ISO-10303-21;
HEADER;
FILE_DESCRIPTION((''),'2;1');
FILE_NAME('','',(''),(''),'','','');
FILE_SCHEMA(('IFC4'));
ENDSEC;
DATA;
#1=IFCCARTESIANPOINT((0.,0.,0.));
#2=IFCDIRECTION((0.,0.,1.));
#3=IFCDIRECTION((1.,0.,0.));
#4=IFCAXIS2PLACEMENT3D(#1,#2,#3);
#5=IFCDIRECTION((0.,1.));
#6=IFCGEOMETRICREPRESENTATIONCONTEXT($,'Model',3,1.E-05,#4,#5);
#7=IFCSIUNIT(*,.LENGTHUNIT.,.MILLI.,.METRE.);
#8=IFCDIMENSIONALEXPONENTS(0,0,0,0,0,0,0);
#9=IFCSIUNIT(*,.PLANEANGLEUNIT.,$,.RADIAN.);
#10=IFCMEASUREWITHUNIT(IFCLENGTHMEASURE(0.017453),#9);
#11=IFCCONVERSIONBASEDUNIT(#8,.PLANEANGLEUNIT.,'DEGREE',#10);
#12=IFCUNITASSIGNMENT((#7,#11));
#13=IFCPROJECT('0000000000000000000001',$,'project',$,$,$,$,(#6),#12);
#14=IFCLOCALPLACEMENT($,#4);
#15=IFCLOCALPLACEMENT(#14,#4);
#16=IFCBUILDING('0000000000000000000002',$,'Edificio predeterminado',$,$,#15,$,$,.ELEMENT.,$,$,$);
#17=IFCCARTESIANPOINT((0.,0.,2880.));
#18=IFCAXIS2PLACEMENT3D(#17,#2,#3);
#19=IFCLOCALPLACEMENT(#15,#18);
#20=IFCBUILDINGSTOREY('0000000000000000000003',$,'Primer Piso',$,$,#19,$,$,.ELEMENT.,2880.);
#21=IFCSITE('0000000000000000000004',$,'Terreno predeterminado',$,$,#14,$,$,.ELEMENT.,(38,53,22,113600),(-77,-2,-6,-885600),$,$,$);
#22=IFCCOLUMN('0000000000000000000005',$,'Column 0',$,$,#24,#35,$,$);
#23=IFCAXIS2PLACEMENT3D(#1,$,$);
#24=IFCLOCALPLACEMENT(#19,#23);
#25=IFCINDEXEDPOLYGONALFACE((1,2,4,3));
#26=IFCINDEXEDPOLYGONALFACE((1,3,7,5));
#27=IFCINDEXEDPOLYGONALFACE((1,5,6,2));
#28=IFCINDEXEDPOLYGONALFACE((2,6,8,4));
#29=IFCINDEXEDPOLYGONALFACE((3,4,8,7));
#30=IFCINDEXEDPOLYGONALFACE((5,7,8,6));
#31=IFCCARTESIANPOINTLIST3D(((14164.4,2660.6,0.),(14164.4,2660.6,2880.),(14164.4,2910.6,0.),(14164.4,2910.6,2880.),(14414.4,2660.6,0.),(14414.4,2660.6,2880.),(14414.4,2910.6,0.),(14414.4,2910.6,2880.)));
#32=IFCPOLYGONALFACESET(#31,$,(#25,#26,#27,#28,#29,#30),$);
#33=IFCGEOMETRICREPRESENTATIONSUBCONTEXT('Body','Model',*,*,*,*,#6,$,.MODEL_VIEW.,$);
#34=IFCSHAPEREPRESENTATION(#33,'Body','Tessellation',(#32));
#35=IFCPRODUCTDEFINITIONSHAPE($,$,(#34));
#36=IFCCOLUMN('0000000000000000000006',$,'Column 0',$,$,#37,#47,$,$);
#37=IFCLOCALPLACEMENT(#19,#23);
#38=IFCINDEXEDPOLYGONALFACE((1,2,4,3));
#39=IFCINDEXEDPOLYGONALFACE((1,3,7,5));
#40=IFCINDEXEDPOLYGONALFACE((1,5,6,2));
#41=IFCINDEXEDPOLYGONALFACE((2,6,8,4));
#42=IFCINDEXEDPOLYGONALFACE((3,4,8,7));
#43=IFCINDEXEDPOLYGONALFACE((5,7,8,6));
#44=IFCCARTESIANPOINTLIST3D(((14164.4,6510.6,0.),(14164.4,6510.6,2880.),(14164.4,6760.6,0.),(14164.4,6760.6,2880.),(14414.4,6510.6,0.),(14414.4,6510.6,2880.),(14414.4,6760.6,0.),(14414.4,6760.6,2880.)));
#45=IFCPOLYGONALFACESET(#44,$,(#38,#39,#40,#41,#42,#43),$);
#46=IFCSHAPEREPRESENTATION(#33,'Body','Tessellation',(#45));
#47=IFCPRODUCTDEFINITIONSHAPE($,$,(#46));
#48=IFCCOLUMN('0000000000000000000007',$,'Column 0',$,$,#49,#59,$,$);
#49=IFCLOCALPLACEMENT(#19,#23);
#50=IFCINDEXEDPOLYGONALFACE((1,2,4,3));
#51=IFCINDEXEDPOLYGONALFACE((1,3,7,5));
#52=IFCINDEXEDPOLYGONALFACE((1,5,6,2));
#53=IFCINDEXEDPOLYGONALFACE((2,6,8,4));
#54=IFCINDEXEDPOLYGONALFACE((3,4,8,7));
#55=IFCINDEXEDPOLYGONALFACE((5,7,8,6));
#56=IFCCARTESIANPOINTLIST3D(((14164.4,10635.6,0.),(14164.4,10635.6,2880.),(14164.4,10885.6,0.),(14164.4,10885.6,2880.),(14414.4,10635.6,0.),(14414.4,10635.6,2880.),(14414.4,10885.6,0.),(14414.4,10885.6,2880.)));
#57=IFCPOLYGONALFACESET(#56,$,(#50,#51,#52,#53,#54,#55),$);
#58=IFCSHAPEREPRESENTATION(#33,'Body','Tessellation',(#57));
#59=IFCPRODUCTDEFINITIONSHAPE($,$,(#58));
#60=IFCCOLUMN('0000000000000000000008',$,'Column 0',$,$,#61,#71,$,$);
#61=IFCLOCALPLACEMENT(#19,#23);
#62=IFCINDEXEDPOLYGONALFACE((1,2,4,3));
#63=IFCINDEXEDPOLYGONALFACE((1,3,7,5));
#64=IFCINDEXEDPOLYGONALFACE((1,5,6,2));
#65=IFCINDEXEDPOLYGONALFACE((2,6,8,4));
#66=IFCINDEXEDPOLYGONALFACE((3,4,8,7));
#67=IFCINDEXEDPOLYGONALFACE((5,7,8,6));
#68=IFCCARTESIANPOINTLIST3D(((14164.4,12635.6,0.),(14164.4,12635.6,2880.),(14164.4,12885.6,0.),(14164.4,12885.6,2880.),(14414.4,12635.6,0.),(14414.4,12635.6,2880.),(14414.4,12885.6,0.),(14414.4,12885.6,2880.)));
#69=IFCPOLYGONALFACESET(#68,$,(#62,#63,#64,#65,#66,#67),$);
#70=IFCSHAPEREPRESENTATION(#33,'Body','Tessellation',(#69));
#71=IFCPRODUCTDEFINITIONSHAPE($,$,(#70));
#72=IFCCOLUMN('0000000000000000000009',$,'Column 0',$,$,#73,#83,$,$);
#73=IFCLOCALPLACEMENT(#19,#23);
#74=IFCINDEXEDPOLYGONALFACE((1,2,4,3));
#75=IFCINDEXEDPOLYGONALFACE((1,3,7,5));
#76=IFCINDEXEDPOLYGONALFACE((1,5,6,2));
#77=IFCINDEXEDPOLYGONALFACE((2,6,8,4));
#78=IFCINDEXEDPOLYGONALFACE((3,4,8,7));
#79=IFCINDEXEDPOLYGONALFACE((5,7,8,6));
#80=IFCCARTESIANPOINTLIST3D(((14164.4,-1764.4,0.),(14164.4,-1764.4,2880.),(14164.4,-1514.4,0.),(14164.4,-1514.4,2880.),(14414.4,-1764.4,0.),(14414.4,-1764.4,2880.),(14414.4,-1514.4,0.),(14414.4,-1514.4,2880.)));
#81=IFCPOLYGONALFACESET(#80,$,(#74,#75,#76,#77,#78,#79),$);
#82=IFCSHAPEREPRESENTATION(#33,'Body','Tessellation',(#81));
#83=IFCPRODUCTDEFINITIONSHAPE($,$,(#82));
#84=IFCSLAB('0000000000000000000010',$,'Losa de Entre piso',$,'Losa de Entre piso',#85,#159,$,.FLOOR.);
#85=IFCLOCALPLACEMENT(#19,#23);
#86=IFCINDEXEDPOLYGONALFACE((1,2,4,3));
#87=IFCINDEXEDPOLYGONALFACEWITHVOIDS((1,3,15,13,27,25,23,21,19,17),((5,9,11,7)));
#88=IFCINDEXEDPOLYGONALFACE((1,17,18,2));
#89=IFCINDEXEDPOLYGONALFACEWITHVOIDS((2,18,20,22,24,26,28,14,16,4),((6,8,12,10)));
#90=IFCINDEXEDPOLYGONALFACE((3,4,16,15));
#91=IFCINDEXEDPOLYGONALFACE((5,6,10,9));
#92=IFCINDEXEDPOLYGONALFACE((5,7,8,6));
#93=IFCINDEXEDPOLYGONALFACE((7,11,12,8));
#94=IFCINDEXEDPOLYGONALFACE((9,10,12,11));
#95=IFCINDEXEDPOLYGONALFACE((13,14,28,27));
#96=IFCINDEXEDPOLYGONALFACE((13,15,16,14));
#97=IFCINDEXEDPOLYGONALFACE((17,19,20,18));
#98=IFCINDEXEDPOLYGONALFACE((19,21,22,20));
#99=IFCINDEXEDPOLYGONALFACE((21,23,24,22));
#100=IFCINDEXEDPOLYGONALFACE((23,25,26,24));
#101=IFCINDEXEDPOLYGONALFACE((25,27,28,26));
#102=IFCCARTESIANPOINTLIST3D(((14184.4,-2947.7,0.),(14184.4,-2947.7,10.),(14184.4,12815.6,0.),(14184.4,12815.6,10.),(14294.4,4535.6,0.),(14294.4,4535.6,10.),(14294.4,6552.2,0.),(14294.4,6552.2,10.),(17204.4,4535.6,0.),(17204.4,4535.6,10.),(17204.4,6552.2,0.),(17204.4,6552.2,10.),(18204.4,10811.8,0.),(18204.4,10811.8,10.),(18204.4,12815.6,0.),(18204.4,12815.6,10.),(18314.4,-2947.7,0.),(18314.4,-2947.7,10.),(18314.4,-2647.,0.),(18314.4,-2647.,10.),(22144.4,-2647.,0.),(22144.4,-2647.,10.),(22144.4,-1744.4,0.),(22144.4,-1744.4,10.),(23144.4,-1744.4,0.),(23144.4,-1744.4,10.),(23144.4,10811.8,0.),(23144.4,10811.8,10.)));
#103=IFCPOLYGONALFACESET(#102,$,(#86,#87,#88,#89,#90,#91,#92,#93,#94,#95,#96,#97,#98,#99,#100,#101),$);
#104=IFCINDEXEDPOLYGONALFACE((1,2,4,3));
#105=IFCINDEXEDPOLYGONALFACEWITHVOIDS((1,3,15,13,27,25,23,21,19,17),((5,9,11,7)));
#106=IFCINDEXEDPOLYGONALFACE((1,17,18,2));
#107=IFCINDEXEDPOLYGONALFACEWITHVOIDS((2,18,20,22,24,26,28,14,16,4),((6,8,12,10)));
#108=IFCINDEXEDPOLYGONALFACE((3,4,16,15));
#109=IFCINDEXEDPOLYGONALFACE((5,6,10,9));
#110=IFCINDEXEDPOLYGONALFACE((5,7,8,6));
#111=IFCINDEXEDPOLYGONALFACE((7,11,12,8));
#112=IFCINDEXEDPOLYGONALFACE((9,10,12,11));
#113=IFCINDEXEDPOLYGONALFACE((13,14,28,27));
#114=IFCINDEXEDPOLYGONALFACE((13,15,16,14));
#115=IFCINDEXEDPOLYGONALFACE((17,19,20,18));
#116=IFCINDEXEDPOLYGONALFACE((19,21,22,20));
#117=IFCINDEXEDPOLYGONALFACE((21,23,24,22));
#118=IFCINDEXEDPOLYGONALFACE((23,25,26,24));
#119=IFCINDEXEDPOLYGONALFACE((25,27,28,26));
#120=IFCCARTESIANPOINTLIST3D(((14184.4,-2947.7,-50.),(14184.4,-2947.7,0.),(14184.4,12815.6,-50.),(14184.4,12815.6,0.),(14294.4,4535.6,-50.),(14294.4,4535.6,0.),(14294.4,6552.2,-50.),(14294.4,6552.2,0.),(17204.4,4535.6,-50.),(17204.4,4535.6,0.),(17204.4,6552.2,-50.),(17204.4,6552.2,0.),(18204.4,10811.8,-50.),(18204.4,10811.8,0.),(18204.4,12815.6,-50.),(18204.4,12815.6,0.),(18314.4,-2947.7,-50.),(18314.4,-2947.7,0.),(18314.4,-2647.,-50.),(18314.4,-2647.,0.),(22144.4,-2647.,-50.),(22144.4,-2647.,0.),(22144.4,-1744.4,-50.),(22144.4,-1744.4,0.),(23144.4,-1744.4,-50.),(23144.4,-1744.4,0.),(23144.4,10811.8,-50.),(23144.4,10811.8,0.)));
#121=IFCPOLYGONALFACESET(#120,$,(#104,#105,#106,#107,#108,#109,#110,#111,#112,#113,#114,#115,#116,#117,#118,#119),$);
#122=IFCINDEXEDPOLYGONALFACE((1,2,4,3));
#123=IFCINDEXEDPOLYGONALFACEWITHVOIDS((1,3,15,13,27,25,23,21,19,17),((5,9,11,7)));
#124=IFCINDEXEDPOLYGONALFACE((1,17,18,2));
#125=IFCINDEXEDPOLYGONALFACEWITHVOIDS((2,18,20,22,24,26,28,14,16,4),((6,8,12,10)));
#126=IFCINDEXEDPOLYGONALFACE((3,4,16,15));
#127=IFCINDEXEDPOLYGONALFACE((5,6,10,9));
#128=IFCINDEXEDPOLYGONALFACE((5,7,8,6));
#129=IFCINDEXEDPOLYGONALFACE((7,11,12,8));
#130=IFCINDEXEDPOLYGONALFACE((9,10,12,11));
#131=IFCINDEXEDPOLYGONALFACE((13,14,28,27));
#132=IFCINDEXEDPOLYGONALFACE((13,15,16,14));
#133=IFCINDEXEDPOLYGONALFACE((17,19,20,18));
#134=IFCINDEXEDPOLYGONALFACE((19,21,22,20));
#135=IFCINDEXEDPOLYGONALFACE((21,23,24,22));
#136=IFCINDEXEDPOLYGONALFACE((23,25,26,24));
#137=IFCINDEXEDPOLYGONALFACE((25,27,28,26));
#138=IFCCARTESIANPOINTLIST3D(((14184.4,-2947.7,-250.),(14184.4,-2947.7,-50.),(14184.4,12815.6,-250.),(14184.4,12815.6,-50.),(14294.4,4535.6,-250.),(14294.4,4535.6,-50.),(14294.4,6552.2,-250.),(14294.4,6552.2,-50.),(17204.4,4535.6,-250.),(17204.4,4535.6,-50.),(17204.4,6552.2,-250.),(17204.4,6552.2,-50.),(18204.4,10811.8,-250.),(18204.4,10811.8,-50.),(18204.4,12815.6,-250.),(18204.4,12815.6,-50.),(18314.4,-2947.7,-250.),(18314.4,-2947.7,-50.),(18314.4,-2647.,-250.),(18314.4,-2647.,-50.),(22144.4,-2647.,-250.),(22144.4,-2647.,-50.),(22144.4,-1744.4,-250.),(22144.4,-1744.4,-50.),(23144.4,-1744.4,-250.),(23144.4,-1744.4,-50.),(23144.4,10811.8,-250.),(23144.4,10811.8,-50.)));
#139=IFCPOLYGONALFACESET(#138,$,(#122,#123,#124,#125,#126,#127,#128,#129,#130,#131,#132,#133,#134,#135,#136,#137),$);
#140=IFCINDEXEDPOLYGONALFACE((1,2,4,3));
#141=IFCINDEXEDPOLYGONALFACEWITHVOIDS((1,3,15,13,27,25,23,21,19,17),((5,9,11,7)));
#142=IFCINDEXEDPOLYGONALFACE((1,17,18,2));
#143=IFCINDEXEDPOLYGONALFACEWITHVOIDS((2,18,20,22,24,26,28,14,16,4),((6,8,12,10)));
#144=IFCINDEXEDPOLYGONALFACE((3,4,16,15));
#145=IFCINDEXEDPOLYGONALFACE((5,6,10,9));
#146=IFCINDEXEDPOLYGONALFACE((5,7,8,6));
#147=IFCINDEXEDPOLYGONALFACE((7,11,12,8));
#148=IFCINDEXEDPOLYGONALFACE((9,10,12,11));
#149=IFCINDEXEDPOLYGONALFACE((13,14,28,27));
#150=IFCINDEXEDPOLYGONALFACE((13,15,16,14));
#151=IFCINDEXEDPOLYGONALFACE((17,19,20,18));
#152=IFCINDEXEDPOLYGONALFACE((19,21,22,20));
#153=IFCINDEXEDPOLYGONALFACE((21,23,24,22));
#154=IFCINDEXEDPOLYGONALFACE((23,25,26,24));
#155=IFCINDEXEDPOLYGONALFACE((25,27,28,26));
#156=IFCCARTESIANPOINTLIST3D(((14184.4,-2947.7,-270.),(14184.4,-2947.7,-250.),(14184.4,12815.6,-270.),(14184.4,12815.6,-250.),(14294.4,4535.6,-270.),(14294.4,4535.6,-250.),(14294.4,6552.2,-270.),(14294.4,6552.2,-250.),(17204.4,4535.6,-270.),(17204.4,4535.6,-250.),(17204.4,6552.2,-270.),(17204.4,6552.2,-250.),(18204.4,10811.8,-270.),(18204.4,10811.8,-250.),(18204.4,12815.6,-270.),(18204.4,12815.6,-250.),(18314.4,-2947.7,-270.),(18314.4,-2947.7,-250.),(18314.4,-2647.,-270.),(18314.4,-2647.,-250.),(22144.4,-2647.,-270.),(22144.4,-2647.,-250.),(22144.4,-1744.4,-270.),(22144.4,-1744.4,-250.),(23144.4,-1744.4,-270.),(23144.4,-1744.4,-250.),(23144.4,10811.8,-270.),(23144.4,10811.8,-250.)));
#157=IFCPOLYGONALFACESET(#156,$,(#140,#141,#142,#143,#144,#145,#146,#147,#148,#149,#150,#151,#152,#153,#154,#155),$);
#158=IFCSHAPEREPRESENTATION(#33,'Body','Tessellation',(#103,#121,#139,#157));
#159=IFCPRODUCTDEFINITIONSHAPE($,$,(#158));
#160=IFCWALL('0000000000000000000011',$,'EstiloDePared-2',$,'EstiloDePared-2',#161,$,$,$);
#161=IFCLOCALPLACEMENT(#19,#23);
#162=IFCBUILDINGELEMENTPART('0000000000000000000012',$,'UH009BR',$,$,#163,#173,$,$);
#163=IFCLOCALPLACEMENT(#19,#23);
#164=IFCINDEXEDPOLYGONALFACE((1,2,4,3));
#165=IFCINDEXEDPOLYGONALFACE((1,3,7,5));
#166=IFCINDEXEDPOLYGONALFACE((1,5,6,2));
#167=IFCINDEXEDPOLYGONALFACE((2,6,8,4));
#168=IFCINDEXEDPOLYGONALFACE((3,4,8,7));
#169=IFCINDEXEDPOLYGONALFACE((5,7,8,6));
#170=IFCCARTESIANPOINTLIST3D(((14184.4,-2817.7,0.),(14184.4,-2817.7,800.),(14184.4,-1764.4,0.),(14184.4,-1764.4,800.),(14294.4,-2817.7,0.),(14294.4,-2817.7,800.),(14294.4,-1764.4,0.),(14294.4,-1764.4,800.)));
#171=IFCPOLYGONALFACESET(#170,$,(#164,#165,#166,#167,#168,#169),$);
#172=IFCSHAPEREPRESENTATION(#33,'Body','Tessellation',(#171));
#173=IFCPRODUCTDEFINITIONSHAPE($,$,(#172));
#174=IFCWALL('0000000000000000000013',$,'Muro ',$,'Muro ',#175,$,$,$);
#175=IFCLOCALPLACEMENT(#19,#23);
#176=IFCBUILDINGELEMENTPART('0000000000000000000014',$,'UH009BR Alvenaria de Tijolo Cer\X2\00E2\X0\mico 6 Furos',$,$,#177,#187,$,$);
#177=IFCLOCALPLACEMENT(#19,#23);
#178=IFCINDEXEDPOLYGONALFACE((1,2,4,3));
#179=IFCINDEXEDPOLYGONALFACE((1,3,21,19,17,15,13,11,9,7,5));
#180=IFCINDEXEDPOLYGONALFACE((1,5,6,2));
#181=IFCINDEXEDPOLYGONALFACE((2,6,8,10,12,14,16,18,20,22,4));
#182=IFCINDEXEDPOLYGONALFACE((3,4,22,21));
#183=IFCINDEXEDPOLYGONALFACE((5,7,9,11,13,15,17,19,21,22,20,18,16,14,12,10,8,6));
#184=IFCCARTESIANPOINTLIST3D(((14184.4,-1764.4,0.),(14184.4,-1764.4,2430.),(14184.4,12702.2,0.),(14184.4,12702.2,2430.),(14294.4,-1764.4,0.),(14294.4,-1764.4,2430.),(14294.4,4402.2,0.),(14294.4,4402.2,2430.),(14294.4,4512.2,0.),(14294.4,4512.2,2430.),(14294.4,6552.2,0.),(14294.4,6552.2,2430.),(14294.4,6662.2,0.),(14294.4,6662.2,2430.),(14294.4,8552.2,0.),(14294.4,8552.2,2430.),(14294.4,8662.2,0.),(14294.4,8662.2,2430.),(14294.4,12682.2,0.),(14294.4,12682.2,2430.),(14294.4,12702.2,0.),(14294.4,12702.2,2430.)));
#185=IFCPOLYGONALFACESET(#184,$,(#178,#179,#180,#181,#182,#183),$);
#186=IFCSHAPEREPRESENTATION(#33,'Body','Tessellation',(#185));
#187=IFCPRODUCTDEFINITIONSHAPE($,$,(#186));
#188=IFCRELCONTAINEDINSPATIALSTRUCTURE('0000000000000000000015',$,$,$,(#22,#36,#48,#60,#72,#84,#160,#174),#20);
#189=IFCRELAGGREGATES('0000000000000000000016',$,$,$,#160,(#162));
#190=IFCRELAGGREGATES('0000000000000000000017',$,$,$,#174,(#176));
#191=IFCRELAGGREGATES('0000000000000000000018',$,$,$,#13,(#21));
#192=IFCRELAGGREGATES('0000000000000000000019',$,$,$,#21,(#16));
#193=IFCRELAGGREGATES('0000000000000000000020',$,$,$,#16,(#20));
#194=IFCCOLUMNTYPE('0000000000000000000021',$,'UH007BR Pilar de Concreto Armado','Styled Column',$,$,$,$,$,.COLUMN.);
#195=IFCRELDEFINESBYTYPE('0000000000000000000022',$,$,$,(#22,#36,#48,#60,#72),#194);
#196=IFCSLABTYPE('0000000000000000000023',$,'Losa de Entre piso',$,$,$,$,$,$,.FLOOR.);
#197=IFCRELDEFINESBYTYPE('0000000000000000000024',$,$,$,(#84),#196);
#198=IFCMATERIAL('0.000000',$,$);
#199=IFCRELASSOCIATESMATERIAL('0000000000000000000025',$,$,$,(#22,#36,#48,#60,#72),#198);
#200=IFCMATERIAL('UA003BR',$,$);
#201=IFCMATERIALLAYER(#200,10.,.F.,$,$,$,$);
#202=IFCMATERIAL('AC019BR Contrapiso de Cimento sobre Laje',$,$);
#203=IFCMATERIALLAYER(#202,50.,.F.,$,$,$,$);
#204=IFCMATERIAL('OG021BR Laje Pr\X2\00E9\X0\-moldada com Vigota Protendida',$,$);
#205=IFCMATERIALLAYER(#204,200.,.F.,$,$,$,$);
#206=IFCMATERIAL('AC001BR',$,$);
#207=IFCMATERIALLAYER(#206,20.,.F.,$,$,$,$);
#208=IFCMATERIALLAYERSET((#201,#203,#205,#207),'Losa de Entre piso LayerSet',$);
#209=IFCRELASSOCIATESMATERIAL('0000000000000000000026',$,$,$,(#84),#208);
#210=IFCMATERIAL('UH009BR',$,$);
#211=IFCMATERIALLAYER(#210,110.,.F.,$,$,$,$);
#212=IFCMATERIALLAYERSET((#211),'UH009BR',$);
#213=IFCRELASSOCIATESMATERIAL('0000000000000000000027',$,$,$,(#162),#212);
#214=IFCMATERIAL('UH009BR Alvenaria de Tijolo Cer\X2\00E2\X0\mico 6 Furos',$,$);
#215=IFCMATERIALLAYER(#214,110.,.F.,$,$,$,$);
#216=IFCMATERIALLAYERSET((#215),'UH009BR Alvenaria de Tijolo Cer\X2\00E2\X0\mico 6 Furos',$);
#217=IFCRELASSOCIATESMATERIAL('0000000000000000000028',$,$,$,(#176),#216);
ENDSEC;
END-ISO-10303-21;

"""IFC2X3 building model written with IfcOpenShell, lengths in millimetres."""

from ifc_helpers import new_model, entity, si_unit, converted_unit, direction, frame, origin_with_axes, place, context, subcontext, project, spatial, polyline, outline, extrude, material, layer, layer_set, layer_usage, type_object, element, aggregate, save


model = new_model("IFC2X3")

# Units and contexts
model_context = context("Model", 3, precision=1e-05, world=origin_with_axes(), true_north=direction((0.0, 1.0)))
body_context = subcontext(model_context, "Body", "Model", "MODEL_VIEW")
ifc_project = project(units=[si_unit("LENGTHUNIT", "METRE", prefix="MILLI"), converted_unit("PLANEANGLEUNIT", "DEGREE", entity("IfcLengthMeasure", 0.017453), si_unit("PLANEANGLEUNIT", "RADIAN"), dimensions=[0, 0, 0, 0, 0, 0, 0])], contexts=[model_context])

# Site, building, storey
site_placement = place(None, origin_with_axes())
site = spatial("IfcSite", under=ifc_project, at=site_placement, Name="Terreno predeterminado", CompositionType="ELEMENT", RefLatitude=(38, 53, 22, 113600), RefLongitude=(-77, -2, -6, -885600))
building_placement = place(site_placement, origin_with_axes())
building = spatial("IfcBuilding", under=site, at=building_placement, Name="Edificio predeterminado", CompositionType="ELEMENT")
storey_placement = place(building_placement, frame((0.0, 0.0, 2880.0), z_axis=(0.0, 0.0, 1.0), x_axis=(1.0, 0.0, 0.0)))
storey = spatial("IfcBuildingStorey", under=building, at=storey_placement, Name="Primer Piso", CompositionType="ELEMENT", Elevation=2880.0)

# Columns
ifc_material_1 = material(Name="0.000000")
column_type = type_object("IfcColumnType", Name="UH007BR Pilar de Concreto Armado", Description="Styled Column", PredefinedType="COLUMN")
for number, where, z_axis, x_axis, name in (
    (1, (14289.4, 2785.6, 0.0), (0.0, 0.0, 1.0), (1.0, 0.0, 0.0), "Column 0"),
    (2, (14289.4, 6635.6, 0.0), (0.0, 0.0, 1.0), (1.0, 0.0, 0.0), "Column 0"),
    (3, (14289.4, 10760.6, 0.0), (0.0, 0.0, 1.0), (1.0, 0.0, 0.0), "Column 0"),
    (4, (14289.4, 12760.6, 0.0), (0.0, 0.0, 1.0), (1.0, 0.0, 0.0), "Column 0"),
    (5, (14289.4, -1639.4, 0.0), (0.0, 0.0, 1.0), (1.0, 0.0, 0.0), "Column 0"),
):
    element("IfcColumn", number, at=place(storey_placement, frame(where, z_axis=z_axis, x_axis=x_axis)), inside=storey, type_object=column_type, material=ifc_material_1, Name=name, context=body_context, shape_type="SweptSolid", body=[
        extrude(outline(polyline([(-125.0, -125.0), (125.0, -125.0), (125.0, 125.0), (-125.0, 125.0), (-125.0, -125.0)])), origin_with_axes(), (0.0, 0.0, 1.0), 2880.0),
    ])

# Slab
ifc_material_2 = material(Name="UA003BR")
ifc_layer_1 = layer(ifc_material_2, 10.0, ventilated=False)
ifc_material_3 = material(Name="AC019BR Contrapiso de Cimento sobre Laje")
ifc_layer_2 = layer(ifc_material_3, 50.0, ventilated=False)
ifc_material_4 = material(Name="OG021BR Laje Pré-moldada com Vigota Protendida")
ifc_layer_3 = layer(ifc_material_4, 200.0, ventilated=False)
ifc_material_5 = material(Name="AC001BR")
ifc_layer_4 = layer(ifc_material_5, 20.0, ventilated=False)
ifc_layer_set_1 = layer_set([ifc_layer_1, ifc_layer_2, ifc_layer_3, ifc_layer_4], Name="Losa de Entre piso LayerSet")
ifc_layer_usage_1 = layer_usage(ifc_layer_set_1, "AXIS3", "NEGATIVE", 0.0)
slab_type = type_object("IfcSlabType", Name="Losa de Entre piso", PredefinedType="FLOOR")
slab_placement = place(storey_placement, frame((0.0, 0.0, -2880.0), z_axis=(0.0, 0.0, 1.0), x_axis=(1.0, 0.0, 0.0)))
element("IfcSlab", 6, at=slab_placement, inside=storey, type_object=slab_type, material=ifc_layer_usage_1, Name="Losa de Entre piso", ObjectType="Losa de Entre piso", PredefinedType="FLOOR", context=body_context, shape_type="SweptSolid", body=[
    extrude(outline(polyline([(0.0, 15763.4), (4130.0, 15763.4), (4130.0, 15462.6), (7960.0, 15462.6), (7960.0, 14560.0), (8960.0, 14560.0), (8960.0, 2003.8), (4020.0, 2003.8), (4020.0, 0.0), (0.0, 0.0), (0.0, 15763.4)]), holes=[polyline([(110.0, 6263.4), (3020.0, 6263.4), (3020.0, 8280.0), (110.0, 8280.0), (110.0, 6263.4)])]), frame((14184.4, 12815.6, 2880.0), z_axis=(0.0, 0.0, -1.0), x_axis=(1.0, 0.0, 0.0)), (0.0, 0.0, -1.0), 10.0),
    extrude(outline(polyline([(0.0, 15763.4), (4130.0, 15763.4), (4130.0, 15462.6), (7960.0, 15462.6), (7960.0, 14560.0), (8960.0, 14560.0), (8960.0, 2003.8), (4020.0, 2003.8), (4020.0, 0.0), (0.0, 0.0), (0.0, 15763.4)]), holes=[polyline([(110.0, 6263.4), (3020.0, 6263.4), (3020.0, 8280.0), (110.0, 8280.0), (110.0, 6263.4)])]), frame((14184.4, 12815.6, 2830.0), z_axis=(0.0, 0.0, -1.0), x_axis=(1.0, 0.0, 0.0)), (0.0, 0.0, -1.0), 50.0),
    extrude(outline(polyline([(0.0, 15763.4), (4130.0, 15763.4), (4130.0, 15462.6), (7960.0, 15462.6), (7960.0, 14560.0), (8960.0, 14560.0), (8960.0, 2003.8), (4020.0, 2003.8), (4020.0, 0.0), (0.0, 0.0), (0.0, 15763.4)]), holes=[polyline([(110.0, 6263.4), (3020.0, 6263.4), (3020.0, 8280.0), (110.0, 8280.0), (110.0, 6263.4)])]), frame((14184.4, 12815.6, 2630.0), z_axis=(0.0, 0.0, -1.0), x_axis=(1.0, 0.0, 0.0)), (0.0, 0.0, -1.0), 200.0),
    extrude(outline(polyline([(0.0, 15763.4), (4130.0, 15763.4), (4130.0, 15462.6), (7960.0, 15462.6), (7960.0, 14560.0), (8960.0, 14560.0), (8960.0, 2003.8), (4020.0, 2003.8), (4020.0, 0.0), (0.0, 0.0), (0.0, 15763.4)]), holes=[polyline([(110.0, 6263.4), (3020.0, 6263.4), (3020.0, 8280.0), (110.0, 8280.0), (110.0, 6263.4)])]), frame((14184.4, 12815.6, 2610.0), z_axis=(0.0, 0.0, -1.0), x_axis=(1.0, 0.0, 0.0)), (0.0, 0.0, -1.0), 20.0),
])

# Walls, building element parts
wall_1_placement = place(storey_placement, frame((14239.4, -2817.7, 0.0), z_axis=(0.0, 0.0, 1.0), x_axis=(0.0, 1.0, 0.0)))
wall_1 = element("IfcWall", 7, at=wall_1_placement, inside=storey, Name="EstiloDePared-2", ObjectType="EstiloDePared-2")
ifc_material_6 = material(Name="UH009BR")
ifc_layer_5 = layer(ifc_material_6, 110.0, ventilated=False)
ifc_layer_set_2 = layer_set([ifc_layer_5], Name="UH009BR")
ifc_layer_usage_2 = layer_usage(ifc_layer_set_2, "AXIS2", "NEGATIVE", -55.0)
building_element_part_1_placement = place(wall_1_placement, origin_with_axes())
building_element_part_1 = element("IfcBuildingElementPart", 8, at=building_element_part_1_placement, material=ifc_layer_usage_2, Name="UH009BR", context=body_context, shape_type="SweptSolid", body=[
    extrude(outline(polyline([(1053.4, 55.0), (1053.4, -55.0), (0.0, -55.0), (0.0, 55.0), (1053.4, 55.0)])), origin_with_axes(), (0.0, 0.0, 1.0), 800.0),
])
aggregate(wall_1, [building_element_part_1])
wall_2_placement = place(storey_placement, frame((14239.4, -1764.4, 0.0), z_axis=(0.0, 0.0, 1.0), x_axis=(0.0, 1.0, 0.0)))
wall_2 = element("IfcWall", 9, at=wall_2_placement, inside=storey, Name="Muro ", ObjectType="Muro ")
ifc_material_7 = material(Name="UH009BR Alvenaria de Tijolo Cerâmico 6 Furos")
ifc_layer_6 = layer(ifc_material_7, 110.0, ventilated=False)
ifc_layer_set_3 = layer_set([ifc_layer_6], Name="UH009BR Alvenaria de Tijolo Cerâmico 6 Furos")
ifc_layer_usage_3 = layer_usage(ifc_layer_set_3, "AXIS2", "NEGATIVE", -55.0)
building_element_part_2_placement = place(wall_2_placement, origin_with_axes())
building_element_part_2 = element("IfcBuildingElementPart", 10, at=building_element_part_2_placement, material=ifc_layer_usage_3, Name="UH009BR Alvenaria de Tijolo Cerâmico 6 Furos", context=body_context, shape_type="SweptSolid", body=[
    extrude(outline(polyline([(14466.6, 55.0), (14466.6, -55.0), (14446.6, -55.0), (10426.6, -55.0), (10316.6, -55.0), (8426.6, -55.0), (8316.6, -55.0), (6276.6, -55.0), (6166.6, -55.0), (0.0, -55.0), (0.0, 55.0), (14466.6, 55.0)])), origin_with_axes(), (0.0, 0.0, 1.0), 2430.0),
])
aggregate(wall_2, [building_element_part_2])

save(model, "model.ifc")
